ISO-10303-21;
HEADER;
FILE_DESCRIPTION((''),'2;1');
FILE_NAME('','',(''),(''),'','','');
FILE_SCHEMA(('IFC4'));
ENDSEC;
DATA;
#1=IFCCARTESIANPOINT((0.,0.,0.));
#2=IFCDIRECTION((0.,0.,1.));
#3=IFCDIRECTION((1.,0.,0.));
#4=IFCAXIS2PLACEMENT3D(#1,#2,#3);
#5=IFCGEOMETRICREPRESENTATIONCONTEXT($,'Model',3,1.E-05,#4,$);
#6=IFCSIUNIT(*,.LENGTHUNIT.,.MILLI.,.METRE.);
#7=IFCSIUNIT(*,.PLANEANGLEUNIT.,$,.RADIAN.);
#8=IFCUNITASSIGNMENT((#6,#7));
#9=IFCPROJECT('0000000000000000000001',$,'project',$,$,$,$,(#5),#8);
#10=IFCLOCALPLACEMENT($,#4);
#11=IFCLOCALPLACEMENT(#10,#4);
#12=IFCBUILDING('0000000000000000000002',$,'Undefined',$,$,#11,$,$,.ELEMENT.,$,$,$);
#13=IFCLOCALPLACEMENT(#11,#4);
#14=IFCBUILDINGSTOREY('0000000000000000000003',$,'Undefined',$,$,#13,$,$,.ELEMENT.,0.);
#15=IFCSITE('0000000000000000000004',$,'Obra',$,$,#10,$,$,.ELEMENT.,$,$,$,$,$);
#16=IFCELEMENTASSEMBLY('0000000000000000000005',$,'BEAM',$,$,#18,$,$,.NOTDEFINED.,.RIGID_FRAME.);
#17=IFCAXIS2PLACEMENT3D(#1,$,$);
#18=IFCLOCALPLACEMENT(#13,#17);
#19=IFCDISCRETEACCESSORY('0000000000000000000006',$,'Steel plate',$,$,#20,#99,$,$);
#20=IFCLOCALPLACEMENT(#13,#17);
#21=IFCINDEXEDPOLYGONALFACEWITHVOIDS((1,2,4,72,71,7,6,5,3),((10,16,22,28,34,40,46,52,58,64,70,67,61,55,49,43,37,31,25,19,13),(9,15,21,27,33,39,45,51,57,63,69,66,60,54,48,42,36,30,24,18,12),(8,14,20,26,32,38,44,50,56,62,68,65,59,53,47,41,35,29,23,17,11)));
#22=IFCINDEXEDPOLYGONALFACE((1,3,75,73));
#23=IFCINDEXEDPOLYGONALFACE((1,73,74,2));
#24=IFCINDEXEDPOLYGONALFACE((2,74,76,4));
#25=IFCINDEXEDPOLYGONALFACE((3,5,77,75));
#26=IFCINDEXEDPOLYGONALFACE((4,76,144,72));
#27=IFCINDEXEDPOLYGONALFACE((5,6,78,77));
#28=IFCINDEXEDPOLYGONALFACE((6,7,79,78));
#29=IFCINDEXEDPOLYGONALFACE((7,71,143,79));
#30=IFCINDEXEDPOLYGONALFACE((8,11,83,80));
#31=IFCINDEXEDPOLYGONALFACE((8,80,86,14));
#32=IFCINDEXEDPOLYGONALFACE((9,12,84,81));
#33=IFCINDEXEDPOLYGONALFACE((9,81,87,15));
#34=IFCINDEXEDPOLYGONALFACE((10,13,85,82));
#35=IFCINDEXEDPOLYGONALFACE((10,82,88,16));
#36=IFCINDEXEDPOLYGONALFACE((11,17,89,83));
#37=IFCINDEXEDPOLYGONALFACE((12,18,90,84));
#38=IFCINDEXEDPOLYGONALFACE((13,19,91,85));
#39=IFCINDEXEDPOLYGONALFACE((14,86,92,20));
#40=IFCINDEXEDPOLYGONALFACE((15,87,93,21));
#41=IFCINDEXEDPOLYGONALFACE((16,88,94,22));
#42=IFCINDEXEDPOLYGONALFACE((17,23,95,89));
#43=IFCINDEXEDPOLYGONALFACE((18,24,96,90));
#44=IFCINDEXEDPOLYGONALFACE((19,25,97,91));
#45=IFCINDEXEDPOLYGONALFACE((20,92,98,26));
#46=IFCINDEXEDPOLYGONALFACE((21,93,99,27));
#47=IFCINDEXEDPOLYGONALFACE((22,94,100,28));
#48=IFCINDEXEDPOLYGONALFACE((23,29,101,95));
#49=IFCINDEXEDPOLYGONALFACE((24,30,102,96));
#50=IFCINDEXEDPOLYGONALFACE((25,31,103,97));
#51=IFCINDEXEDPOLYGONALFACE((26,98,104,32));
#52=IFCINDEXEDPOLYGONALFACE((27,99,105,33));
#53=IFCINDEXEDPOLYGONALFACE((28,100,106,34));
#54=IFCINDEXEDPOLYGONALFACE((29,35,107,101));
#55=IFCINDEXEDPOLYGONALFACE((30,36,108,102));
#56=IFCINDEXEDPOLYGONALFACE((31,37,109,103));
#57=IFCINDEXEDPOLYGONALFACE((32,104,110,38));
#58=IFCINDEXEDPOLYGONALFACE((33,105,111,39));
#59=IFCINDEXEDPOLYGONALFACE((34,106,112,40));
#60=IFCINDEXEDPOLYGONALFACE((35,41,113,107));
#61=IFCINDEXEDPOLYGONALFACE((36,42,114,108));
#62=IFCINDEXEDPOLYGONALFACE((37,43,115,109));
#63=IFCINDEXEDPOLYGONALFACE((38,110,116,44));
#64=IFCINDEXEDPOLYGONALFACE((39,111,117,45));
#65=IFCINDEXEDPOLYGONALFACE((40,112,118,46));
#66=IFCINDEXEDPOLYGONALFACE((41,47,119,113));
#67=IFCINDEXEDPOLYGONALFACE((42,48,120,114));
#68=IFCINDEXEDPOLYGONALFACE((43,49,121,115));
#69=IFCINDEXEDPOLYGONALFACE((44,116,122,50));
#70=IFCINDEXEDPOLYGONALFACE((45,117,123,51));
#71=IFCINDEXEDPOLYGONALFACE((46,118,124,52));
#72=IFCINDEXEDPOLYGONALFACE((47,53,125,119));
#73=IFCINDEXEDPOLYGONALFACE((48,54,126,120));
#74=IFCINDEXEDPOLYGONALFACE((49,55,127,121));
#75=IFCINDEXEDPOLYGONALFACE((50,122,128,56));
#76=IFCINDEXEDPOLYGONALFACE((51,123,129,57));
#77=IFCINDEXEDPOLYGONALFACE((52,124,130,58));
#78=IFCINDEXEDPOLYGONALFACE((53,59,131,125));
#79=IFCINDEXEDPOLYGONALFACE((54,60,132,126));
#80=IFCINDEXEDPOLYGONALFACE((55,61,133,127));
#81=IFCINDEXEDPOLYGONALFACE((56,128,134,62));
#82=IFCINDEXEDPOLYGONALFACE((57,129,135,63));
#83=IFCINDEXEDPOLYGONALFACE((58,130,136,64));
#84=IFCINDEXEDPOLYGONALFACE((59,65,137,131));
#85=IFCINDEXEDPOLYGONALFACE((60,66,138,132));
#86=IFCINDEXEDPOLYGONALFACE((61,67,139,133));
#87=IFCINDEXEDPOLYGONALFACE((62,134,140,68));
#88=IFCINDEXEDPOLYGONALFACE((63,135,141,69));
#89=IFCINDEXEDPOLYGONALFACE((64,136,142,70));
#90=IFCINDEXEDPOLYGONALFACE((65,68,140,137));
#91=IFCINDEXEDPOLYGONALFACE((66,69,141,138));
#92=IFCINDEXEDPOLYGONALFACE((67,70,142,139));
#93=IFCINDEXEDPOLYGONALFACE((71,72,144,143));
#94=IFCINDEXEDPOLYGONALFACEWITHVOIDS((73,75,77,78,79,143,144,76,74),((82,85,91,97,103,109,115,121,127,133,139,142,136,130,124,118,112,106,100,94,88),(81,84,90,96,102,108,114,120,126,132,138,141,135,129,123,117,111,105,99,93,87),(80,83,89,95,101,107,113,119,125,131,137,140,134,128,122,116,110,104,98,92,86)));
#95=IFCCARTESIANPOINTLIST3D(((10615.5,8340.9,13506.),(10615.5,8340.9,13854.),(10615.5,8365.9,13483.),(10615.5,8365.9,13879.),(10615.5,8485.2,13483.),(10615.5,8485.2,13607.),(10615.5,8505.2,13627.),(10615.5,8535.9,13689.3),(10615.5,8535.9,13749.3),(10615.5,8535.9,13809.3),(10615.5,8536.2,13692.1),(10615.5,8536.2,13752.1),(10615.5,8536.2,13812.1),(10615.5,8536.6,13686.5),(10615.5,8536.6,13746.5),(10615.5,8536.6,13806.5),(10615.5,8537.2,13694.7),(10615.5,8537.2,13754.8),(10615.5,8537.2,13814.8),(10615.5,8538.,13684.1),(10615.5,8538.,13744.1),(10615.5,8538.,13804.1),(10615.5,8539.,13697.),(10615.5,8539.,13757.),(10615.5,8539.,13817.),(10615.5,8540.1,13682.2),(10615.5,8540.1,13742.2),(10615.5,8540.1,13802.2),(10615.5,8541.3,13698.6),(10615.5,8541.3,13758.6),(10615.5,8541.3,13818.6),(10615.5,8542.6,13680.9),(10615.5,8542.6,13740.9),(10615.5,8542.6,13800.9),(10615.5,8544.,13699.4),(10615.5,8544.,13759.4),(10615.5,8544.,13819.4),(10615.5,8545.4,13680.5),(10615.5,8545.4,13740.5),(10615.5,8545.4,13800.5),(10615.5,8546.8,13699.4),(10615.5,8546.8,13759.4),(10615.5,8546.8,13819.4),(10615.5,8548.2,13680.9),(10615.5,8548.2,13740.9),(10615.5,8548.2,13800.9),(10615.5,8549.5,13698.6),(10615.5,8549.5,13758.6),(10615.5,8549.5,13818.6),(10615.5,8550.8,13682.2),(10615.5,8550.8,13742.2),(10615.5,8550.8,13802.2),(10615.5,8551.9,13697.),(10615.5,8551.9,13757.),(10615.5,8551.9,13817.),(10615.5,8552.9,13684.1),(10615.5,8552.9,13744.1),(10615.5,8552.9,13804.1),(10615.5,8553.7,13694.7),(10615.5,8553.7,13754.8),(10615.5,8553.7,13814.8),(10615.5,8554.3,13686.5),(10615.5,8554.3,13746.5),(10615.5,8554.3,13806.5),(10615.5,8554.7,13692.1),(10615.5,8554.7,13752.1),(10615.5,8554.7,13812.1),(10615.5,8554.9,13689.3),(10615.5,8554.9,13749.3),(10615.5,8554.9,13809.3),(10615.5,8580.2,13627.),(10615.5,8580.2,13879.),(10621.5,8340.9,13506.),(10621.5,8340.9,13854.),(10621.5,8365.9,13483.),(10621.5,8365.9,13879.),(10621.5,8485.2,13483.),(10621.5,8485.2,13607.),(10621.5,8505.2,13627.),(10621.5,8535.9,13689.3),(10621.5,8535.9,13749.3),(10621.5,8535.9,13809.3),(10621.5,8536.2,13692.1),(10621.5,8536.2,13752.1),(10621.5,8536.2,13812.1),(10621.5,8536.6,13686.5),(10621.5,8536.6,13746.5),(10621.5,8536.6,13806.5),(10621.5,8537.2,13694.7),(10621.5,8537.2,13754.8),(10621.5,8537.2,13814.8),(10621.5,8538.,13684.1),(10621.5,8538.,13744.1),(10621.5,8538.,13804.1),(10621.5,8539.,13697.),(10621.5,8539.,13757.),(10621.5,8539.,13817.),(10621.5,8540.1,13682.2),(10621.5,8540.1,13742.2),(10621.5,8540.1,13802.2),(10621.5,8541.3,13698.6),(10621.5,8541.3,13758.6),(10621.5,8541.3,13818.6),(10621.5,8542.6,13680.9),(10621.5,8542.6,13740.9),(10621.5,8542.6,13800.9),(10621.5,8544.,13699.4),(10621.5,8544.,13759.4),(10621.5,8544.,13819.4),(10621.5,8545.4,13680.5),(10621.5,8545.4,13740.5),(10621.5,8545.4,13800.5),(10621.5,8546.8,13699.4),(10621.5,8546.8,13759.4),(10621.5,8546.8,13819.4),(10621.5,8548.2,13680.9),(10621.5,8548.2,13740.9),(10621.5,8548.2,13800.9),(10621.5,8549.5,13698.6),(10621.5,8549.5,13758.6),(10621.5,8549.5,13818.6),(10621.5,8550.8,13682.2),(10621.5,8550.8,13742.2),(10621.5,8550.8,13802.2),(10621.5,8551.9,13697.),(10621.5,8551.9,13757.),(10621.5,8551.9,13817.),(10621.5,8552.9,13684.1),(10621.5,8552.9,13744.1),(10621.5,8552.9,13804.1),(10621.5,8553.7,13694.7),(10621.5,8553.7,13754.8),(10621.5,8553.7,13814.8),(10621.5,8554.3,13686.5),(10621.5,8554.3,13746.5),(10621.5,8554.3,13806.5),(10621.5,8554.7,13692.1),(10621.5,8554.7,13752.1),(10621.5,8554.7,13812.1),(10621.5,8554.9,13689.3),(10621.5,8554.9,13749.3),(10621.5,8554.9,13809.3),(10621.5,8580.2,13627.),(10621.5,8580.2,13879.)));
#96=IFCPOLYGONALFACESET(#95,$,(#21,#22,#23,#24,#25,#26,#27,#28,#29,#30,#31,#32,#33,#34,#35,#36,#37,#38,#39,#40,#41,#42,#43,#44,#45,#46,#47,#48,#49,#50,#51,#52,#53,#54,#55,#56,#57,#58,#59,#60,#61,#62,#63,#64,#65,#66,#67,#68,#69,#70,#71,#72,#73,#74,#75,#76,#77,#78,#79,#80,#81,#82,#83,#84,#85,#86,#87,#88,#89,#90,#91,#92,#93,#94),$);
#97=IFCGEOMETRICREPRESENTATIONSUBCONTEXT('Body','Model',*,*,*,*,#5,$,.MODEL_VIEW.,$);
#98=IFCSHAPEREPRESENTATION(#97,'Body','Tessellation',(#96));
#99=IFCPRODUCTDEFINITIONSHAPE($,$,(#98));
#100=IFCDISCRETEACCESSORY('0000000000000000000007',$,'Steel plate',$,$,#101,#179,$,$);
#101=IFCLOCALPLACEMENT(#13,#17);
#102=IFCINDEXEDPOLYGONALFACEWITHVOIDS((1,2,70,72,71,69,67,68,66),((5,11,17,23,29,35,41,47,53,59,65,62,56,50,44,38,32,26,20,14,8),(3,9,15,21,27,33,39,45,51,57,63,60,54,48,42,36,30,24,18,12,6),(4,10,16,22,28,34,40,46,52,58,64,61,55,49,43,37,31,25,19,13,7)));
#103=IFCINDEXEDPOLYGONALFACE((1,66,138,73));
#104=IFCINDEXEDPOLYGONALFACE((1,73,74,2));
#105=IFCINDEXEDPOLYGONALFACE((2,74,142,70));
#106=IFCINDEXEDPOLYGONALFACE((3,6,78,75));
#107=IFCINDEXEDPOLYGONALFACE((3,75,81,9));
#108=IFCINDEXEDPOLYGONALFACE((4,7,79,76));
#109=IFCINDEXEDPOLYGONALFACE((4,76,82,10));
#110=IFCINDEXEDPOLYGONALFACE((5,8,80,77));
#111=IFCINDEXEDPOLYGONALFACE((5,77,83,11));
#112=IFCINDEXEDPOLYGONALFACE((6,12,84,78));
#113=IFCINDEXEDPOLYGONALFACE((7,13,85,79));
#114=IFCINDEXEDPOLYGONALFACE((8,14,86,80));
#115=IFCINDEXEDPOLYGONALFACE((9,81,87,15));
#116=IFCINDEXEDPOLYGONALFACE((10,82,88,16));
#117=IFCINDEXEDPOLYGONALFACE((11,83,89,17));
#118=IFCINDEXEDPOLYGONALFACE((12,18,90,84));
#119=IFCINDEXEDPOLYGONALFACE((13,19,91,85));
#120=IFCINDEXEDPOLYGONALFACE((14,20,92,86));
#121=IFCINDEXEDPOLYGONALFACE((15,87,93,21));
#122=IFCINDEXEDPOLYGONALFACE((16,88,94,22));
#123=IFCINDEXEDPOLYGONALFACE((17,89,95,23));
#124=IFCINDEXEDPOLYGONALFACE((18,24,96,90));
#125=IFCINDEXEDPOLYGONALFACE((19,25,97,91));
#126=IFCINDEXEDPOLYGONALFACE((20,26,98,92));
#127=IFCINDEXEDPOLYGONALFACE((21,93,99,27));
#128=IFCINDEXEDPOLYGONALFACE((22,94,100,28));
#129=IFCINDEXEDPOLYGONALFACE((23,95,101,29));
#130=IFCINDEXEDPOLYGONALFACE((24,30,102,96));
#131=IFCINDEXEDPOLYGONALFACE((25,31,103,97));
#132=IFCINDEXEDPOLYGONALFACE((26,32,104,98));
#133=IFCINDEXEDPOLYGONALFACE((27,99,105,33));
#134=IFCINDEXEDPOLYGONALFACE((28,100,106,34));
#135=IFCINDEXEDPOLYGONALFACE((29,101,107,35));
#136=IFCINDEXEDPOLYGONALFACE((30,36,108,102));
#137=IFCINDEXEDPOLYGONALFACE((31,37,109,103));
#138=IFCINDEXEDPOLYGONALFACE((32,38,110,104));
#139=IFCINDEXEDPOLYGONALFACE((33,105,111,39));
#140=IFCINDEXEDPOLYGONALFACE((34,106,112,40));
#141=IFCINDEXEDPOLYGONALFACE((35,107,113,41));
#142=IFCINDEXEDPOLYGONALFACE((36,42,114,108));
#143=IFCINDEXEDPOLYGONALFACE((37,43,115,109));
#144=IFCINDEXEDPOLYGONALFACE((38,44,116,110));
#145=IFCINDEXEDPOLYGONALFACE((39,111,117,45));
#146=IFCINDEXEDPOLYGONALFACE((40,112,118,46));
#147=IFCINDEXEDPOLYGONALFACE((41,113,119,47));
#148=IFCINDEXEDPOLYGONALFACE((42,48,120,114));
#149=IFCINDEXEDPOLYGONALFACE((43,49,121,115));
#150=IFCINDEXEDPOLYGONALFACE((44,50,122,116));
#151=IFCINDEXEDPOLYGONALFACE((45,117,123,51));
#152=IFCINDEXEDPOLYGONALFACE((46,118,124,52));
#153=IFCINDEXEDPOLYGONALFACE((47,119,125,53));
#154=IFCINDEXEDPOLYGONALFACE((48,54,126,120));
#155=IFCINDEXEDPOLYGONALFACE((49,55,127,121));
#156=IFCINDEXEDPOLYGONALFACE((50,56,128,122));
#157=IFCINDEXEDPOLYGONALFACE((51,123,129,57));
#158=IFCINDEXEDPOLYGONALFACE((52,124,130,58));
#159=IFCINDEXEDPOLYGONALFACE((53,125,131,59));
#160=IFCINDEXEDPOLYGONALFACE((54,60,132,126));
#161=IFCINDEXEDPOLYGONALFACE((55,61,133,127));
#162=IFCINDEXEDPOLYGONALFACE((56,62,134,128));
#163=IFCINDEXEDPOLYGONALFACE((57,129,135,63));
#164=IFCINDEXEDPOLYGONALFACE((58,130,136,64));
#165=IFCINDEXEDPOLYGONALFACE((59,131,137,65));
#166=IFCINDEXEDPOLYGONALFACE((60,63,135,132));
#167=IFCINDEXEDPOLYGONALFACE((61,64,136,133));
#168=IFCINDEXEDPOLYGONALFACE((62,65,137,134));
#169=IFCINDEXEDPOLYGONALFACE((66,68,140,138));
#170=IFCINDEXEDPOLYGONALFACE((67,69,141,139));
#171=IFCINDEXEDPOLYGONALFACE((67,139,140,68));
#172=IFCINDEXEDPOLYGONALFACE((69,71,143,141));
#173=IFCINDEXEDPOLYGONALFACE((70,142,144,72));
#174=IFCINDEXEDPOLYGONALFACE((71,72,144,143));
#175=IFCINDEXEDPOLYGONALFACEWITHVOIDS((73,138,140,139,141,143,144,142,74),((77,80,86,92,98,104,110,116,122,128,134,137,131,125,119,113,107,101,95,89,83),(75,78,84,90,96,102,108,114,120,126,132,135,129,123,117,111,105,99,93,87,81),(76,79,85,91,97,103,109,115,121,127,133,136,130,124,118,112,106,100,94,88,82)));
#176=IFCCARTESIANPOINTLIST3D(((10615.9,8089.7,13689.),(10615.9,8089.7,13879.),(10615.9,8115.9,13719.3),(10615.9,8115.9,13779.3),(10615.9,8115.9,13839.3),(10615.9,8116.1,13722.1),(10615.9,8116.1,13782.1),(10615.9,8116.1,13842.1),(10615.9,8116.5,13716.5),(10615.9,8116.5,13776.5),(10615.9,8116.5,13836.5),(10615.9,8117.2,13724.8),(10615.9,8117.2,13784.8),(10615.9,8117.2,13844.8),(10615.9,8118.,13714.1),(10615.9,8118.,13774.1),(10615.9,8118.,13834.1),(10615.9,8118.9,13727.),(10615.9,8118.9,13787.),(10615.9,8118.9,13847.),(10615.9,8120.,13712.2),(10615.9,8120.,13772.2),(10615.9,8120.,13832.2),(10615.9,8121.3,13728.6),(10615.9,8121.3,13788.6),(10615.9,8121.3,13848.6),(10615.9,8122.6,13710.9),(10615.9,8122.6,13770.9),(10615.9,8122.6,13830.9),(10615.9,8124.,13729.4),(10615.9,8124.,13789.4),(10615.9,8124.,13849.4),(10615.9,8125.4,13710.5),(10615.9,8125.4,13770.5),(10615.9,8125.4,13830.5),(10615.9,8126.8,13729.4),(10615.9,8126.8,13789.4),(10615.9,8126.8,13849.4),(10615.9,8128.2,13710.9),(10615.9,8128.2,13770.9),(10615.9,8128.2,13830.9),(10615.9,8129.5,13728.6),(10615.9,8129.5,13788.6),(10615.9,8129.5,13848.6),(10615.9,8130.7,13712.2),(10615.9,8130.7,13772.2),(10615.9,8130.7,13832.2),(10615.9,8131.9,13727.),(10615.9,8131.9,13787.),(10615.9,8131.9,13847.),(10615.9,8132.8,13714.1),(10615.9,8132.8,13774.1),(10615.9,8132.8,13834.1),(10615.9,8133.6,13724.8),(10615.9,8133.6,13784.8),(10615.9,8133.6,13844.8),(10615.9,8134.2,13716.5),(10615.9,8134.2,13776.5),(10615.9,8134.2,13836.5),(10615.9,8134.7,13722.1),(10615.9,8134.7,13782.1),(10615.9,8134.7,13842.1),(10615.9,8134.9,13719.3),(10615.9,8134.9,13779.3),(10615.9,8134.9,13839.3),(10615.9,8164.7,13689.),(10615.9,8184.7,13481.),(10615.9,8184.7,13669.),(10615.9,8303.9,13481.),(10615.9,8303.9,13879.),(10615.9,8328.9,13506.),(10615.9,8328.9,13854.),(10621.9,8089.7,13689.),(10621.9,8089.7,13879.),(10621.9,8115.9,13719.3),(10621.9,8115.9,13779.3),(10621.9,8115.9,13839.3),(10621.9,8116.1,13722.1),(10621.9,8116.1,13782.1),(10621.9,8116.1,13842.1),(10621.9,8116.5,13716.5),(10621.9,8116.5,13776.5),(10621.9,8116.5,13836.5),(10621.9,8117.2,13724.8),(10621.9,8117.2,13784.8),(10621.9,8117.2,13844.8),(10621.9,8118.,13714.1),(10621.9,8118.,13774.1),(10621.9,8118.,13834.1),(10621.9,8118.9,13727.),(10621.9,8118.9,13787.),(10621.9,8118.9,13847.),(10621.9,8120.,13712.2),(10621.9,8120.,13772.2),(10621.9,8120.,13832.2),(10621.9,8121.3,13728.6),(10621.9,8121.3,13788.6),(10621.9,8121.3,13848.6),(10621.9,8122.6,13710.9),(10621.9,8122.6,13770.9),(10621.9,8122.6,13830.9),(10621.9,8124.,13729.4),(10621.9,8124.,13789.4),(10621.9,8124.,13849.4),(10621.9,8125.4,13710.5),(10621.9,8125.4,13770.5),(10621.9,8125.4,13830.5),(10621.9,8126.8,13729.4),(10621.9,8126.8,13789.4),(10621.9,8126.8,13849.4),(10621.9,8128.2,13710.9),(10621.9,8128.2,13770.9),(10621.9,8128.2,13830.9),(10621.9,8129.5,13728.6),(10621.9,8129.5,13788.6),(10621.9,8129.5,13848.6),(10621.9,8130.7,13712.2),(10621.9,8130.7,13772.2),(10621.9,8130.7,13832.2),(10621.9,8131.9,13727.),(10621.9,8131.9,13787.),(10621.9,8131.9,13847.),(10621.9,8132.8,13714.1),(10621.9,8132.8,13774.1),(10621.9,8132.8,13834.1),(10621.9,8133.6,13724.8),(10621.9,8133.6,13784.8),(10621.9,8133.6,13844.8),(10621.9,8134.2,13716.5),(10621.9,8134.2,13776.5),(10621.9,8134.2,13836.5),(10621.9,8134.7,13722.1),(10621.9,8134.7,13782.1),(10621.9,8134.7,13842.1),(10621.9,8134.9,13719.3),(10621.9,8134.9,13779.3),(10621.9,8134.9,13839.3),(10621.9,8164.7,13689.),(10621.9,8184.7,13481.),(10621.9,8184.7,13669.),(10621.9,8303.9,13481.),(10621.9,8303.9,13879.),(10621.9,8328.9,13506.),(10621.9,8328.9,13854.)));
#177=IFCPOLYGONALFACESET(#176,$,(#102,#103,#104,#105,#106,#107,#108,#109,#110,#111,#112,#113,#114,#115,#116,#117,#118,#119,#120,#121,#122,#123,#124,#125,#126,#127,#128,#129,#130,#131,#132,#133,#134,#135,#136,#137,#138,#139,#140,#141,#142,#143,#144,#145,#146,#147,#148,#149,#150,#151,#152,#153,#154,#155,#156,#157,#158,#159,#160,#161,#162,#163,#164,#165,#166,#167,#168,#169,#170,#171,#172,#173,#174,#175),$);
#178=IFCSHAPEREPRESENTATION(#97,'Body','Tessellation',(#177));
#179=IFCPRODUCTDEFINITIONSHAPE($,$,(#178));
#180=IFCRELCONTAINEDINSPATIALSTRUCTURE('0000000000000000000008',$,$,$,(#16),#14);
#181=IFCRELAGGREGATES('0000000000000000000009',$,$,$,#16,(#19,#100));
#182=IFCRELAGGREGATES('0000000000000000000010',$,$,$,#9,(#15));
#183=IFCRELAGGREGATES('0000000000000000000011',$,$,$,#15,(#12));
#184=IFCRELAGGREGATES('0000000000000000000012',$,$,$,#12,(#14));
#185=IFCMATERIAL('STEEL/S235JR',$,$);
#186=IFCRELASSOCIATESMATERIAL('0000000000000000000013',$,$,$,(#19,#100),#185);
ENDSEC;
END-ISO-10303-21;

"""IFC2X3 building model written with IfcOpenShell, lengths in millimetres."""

from ifc_helpers import new_model, si_unit, frame, origin_with_axes, origin_2d_with_axis, place, context, subcontext, project, spatial, polyline, circle, outline, extrude, source, transform, mapped, material, element, aggregate, save


model = new_model("IFC2X3")

# Units and contexts
model_context = context("Model", 3, precision=1e-05, world=origin_with_axes())
body_context = subcontext(model_context, "Body", "Model", "MODEL_VIEW")
ifc_project = project(units=[si_unit("LENGTHUNIT", "METRE", prefix="MILLI"), si_unit("PLANEANGLEUNIT", "RADIAN")], contexts=[model_context])

# Site, building, storey
site_placement = place(None, origin_with_axes())
site = spatial("IfcSite", under=ifc_project, at=site_placement, Name="Obra", CompositionType="ELEMENT")
building_placement = place(site_placement, origin_with_axes())
building = spatial("IfcBuilding", under=site, at=building_placement, Name="Undefined", CompositionType="ELEMENT")
storey_placement = place(building_placement, origin_with_axes())
storey = spatial("IfcBuildingStorey", under=building, at=storey_placement, Name="Undefined", CompositionType="ELEMENT", Elevation=0.0)

# Shared definitions
ifc_material_1 = material(Name="STEEL/S235JR")

# Element assembly
assembly_1_placement = place(storey_placement, origin_with_axes())
assembly_1 = element("IfcElementAssembly", 1, at=assembly_1_placement, inside=storey, Name="BEAM", AssemblyPlace="NOTDEFINED", PredefinedType="RIGID_FRAME")

# Discrete accessories, openings
discrete_accessory_1_placement = place(assembly_1_placement, frame((10618.5, 8340.9, 13506.0), z_axis=(1.0, 0.0, 0.0), x_axis=(0.0, 0.735931, -0.677057)))
discrete_accessory_1 = element("IfcDiscreteAccessory", 2, at=discrete_accessory_1_placement, material=ifc_material_1, Name="Steel plate", context=body_context, shape_type="SweptSolid", body=[
    extrude(outline(polyline([(0.0, 0.0), (34.0, 0.0), (121.7, 80.7), (37.8, 172.0), (39.0, 200.3), (94.1, 251.0), (-76.5, 436.5), (-234.1, 291.4), (-235.6, 256.1), (0.0, 0.0)])), frame((0.0, 0.0, -3.0), z_axis=(0.0, 0.0, 1.0), x_axis=(1.0, 0.0, 0.0)), (0.0, 0.0, 1.0), 6.0),
])
shared_shape_1 = source(origin_with_axes(), body_context, "Body", "SweptSolid", [
    extrude(circle(Radius=9.5, at=origin_2d_with_axis()), frame((0.0, 3.4, 0.0), z_axis=(0.0, 1.0, 0.0), x_axis=(1.0, 0.0, 0.0)), (0.0, 0.0, 1.0), 6.2),
])
opening_1_placement = place(assembly_1_placement, frame((10625.0, 8545.4, 13810.0), z_axis=(0.0, 1.0, 0.0), x_axis=(0.0, 0.0, -1.0)))
element("IfcOpeningElement", 3, at=opening_1_placement, cuts=discrete_accessory_1, ObjectType="Opening", context=body_context, shape_type="MappedRepresentation", body=[
    mapped(shared_shape_1, transform((0.0, 0.0, 0.0))),
    mapped(shared_shape_1, transform((60.0, 0.0, 0.0))),
    mapped(shared_shape_1, transform((120.0, 0.0, 0.0))),
])
discrete_accessory_2_placement = place(assembly_1_placement, frame((10618.9, 8328.9, 13506.0), z_axis=(-1.0, 0.0, 0.0), x_axis=(0.000001, -0.707107, -0.707107)))
discrete_accessory_2 = element("IfcDiscreteAccessory", 4, at=discrete_accessory_2_placement, material=ifc_material_1, Name="Steel plate", context=body_context, shape_type="SweptSolid", body=[
    extrude(outline(polyline([(0.0, 0.0), (35.4, 0.0), (119.7, 84.3), (-13.3, 217.3), (-13.3, 245.5), (39.8, 298.6), (-94.6, 432.9), (-246.1, 281.4), (-246.1, 246.1), (0.0, 0.0)])), frame((0.0, 0.0, -3.0), z_axis=(0.0, 0.0, 1.0), x_axis=(1.0, 0.0, 0.0)), (0.0, 0.0, 1.0), 6.0),
])
shared_shape_2 = source(origin_with_axes(), body_context, "Body", "SweptSolid", [
    extrude(circle(Radius=9.5, at=origin_2d_with_axis()), frame((0.0, -9.2, 0.0), z_axis=(0.0, 1.0, 0.0), x_axis=(1.0, 0.0, 0.0)), (0.0, 0.0, 1.0), 6.2),
])
opening_2_placement = place(assembly_1_placement, frame((10625.0, 8125.4, 13840.0), z_axis=(0.0, -1.0, 0.0), x_axis=(0.0, 0.0, -1.0)))
element("IfcOpeningElement", 5, at=opening_2_placement, cuts=discrete_accessory_2, ObjectType="Opening", context=body_context, shape_type="MappedRepresentation", body=[
    mapped(shared_shape_2, transform((0.0, 0.0, 0.0))),
    mapped(shared_shape_2, transform((60.0, 0.0, 0.0))),
    mapped(shared_shape_2, transform((120.0, 0.0, 0.0))),
])
aggregate(assembly_1, [discrete_accessory_1, discrete_accessory_2])

save(model, "model.ifc")
